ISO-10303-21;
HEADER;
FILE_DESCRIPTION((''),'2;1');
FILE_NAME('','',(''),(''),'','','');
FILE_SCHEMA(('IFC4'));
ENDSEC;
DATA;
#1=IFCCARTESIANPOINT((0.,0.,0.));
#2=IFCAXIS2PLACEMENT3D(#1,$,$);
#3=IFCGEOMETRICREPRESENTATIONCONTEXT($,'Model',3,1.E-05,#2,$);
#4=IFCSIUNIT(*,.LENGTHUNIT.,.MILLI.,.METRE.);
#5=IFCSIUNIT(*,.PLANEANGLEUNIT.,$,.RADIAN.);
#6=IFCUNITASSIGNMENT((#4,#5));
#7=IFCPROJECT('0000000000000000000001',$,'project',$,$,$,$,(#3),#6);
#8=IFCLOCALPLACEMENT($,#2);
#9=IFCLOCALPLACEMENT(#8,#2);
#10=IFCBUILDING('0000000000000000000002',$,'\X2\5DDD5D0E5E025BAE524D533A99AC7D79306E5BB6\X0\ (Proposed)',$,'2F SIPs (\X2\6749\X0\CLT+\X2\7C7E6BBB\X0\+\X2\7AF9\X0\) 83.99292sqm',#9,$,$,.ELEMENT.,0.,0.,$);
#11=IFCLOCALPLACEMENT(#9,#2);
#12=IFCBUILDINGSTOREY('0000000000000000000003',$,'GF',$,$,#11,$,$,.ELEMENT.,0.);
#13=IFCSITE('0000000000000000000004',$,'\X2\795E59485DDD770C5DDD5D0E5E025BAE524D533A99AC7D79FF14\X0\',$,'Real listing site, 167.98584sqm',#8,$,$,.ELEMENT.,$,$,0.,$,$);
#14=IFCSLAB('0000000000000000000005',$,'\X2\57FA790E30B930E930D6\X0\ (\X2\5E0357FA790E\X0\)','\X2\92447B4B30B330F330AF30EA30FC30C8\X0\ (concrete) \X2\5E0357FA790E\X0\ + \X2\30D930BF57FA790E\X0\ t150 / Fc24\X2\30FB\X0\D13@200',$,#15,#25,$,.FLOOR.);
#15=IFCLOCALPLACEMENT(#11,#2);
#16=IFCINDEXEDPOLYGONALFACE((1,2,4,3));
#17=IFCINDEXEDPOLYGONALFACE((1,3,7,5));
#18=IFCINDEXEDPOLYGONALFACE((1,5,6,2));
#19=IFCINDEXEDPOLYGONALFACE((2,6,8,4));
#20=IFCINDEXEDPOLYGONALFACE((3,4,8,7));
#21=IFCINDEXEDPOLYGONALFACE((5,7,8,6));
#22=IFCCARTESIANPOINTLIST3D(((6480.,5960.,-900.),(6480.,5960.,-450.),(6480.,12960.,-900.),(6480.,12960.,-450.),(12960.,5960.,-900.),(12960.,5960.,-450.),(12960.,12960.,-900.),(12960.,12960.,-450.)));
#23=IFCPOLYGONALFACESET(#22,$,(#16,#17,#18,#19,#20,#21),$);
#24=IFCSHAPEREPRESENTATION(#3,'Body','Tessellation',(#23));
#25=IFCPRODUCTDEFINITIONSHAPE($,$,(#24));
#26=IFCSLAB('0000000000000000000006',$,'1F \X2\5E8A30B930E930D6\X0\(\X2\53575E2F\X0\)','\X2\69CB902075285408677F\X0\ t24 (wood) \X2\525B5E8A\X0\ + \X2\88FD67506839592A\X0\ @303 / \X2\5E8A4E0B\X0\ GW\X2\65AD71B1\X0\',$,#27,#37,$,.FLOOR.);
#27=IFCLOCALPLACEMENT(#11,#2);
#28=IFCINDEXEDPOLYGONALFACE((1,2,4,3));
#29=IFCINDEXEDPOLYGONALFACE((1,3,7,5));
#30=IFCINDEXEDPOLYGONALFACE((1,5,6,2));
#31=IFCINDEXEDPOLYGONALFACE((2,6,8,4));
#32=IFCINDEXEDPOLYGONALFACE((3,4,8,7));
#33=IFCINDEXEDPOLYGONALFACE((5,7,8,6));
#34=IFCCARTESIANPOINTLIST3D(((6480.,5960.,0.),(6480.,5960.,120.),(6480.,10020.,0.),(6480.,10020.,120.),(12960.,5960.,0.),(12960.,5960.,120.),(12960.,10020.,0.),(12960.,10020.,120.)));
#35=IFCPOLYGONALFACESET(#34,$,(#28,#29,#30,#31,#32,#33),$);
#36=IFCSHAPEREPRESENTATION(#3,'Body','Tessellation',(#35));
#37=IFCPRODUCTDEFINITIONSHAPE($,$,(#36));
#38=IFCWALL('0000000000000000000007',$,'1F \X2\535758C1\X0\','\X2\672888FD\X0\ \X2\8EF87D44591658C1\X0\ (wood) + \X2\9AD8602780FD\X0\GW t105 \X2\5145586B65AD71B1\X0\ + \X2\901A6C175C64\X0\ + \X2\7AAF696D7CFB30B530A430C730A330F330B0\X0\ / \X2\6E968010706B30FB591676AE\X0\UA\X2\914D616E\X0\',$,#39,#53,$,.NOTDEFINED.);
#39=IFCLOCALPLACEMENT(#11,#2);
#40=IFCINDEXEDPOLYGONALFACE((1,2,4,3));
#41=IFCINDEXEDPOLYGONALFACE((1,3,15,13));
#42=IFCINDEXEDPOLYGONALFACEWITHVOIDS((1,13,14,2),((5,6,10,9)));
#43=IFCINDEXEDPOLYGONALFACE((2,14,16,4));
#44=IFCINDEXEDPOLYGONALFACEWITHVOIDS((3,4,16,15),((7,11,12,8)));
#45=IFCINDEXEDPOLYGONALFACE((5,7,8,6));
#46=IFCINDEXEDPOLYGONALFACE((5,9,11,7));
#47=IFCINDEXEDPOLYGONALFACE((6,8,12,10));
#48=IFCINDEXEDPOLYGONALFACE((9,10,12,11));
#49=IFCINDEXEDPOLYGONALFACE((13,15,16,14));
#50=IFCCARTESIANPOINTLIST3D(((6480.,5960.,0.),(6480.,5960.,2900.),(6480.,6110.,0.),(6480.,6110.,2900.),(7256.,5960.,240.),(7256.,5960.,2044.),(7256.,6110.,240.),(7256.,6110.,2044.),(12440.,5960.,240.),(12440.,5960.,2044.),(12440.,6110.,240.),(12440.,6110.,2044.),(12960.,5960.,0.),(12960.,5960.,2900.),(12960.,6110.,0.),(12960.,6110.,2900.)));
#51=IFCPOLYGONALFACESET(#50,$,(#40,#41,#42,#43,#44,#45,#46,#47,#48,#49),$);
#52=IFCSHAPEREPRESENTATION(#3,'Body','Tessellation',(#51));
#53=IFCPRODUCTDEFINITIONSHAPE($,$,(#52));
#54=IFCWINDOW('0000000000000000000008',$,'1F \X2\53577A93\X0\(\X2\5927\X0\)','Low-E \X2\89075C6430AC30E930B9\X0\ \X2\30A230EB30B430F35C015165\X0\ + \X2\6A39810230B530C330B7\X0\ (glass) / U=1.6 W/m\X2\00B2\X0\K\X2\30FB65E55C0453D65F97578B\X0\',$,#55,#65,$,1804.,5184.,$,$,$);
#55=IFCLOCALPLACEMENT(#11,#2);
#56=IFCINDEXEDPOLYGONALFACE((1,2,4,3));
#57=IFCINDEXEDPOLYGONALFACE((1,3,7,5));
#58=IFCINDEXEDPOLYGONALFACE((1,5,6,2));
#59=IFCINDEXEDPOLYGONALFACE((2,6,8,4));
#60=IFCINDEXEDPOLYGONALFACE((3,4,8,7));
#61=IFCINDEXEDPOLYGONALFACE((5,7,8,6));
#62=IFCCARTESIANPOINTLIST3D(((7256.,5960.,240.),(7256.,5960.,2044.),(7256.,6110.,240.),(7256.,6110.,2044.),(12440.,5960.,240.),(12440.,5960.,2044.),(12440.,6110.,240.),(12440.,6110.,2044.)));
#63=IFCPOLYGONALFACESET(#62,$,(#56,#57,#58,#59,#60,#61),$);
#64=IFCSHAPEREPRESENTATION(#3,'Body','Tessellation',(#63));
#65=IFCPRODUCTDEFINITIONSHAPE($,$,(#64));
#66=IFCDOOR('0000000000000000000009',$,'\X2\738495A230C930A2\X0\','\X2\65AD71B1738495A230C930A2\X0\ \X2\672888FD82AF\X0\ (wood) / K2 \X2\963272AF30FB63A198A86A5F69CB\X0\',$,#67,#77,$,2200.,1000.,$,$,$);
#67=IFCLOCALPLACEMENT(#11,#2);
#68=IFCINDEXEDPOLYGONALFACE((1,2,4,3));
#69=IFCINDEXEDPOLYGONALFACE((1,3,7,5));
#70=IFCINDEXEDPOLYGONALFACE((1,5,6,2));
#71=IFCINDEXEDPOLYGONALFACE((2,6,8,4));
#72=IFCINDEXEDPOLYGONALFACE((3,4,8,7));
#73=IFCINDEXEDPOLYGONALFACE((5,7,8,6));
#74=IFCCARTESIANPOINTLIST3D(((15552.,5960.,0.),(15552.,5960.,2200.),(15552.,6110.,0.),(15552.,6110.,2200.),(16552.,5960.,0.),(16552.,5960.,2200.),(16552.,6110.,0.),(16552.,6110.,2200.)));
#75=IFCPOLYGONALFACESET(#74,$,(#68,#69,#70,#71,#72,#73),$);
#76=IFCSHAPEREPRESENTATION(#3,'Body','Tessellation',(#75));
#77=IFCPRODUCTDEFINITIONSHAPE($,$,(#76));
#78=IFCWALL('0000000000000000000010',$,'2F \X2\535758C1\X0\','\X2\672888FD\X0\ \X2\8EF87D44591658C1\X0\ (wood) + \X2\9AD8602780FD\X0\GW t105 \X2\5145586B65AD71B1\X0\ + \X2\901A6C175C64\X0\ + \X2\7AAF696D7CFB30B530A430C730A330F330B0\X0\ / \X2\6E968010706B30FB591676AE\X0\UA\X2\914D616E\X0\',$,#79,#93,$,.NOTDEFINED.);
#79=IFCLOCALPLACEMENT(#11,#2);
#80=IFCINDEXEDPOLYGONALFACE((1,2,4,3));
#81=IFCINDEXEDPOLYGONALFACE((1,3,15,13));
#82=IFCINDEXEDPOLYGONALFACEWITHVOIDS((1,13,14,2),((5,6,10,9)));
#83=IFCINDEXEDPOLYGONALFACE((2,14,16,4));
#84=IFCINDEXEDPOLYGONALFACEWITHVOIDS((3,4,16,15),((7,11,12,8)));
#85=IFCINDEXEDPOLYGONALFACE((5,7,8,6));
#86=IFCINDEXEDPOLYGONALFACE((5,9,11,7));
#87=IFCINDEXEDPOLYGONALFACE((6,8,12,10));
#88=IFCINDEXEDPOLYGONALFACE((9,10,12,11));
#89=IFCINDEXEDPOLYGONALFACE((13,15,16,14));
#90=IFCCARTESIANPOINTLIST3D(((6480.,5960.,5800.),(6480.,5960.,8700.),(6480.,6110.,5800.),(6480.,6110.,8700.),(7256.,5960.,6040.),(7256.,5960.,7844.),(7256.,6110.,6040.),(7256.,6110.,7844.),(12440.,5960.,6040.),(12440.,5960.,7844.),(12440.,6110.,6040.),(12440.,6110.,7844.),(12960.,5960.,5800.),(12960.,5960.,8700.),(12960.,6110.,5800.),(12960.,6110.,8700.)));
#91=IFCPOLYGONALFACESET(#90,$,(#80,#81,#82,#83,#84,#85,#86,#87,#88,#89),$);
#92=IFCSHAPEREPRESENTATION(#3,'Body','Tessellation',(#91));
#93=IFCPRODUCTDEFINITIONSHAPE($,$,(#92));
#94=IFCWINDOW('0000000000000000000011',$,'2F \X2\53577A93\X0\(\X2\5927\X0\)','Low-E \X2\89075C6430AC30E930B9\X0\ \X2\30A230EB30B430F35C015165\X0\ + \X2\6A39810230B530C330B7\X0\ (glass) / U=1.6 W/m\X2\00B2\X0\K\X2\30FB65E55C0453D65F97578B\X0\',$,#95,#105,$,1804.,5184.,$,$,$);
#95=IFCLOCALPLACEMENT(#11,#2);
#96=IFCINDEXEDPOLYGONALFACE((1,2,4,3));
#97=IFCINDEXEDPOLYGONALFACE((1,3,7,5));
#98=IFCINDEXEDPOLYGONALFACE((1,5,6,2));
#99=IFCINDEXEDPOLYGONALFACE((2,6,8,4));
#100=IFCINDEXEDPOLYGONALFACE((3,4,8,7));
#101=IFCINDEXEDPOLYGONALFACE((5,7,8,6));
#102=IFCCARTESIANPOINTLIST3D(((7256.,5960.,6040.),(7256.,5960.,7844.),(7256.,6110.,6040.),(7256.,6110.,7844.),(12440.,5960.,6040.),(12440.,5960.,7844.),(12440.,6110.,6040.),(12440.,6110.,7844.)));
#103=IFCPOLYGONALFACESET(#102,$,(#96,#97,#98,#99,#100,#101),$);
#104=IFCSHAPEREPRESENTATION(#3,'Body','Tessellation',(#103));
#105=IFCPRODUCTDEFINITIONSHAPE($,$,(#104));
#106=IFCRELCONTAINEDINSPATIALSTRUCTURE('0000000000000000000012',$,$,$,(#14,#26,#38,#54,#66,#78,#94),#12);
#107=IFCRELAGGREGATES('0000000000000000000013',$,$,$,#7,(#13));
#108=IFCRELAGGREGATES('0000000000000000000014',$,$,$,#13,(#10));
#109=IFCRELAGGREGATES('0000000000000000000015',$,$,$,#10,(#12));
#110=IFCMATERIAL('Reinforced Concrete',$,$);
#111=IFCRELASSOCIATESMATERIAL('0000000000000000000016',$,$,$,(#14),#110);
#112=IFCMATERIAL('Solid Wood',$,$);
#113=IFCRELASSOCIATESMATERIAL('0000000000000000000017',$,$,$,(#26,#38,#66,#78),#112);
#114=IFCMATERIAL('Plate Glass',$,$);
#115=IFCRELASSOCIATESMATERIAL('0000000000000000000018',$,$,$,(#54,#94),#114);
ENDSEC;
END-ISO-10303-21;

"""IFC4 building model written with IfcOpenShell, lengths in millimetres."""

from ifc_helpers import new_model, si_unit, frame, frame_2d, origin, place, context, project, spatial, rectangle, extrude, material, element, fill, save


model = new_model("IFC4")

# Units and contexts
model_context = context("Model", 3, precision=1e-05, world=origin())
ifc_project = project(units=[si_unit("LENGTHUNIT", "METRE", prefix="MILLI"), si_unit("PLANEANGLEUNIT", "RADIAN")], contexts=[model_context])

# Site, building, storey
site_placement = place(None, origin())
site = spatial("IfcSite", under=ifc_project, at=site_placement, Name="神奈川県川崎市宮前区馬絹４", ObjectType="Real listing site, 167.98584sqm", CompositionType="ELEMENT", RefElevation=0.0)
building_placement = place(site_placement, origin())
building = spatial("IfcBuilding", under=site, at=building_placement, Name="川崎市宮前区馬絹の家 (Proposed)", ObjectType="2F SIPs (杉CLT+籾殻+竹) 83.99292sqm", CompositionType="ELEMENT", ElevationOfRefHeight=0.0, ElevationOfTerrain=0.0)
storey_placement = place(building_placement, origin())
storey = spatial("IfcBuildingStorey", under=building, at=storey_placement, Name="GF", CompositionType="ELEMENT", Elevation=0.0)

# Slabs
ifc_material_1 = material(Name="Reinforced Concrete")
slab_1_placement = place(storey_placement, frame((3240.0, 2980.0, -450.0)))
element("IfcSlab", 1, at=slab_1_placement, inside=storey, material=ifc_material_1, Name="基礎スラブ (布基礎)", Description="鉄筋コンクリート (concrete) 布基礎 + ベタ基礎 t150 / Fc24・D13@200", PredefinedType="FLOOR", context=model_context, shape_type="SweptSolid", body=[
    extrude(rectangle(XDim=6480.0, YDim=7000.0, at=frame_2d((3240.0, 3500.0))), frame((3240.0, 2980.0, -450.0)), (0.0, 0.0, 1.0), 450.0),
])
ifc_material_2 = material(Name="Solid Wood")
slab_2_placement = place(storey_placement, frame((3240.0, 2980.0, 0.0)))
element("IfcSlab", 2, at=slab_2_placement, inside=storey, material=ifc_material_2, Name="1F 床スラブ(南帯)", Description="構造用合板 t24 (wood) 剛床 + 製材根太 @303 / 床下 GW断熱", PredefinedType="FLOOR", context=model_context, shape_type="SweptSolid", body=[
    extrude(rectangle(XDim=6480.0, YDim=4060.0, at=frame_2d((3240.0, 2030.0))), frame((3240.0, 2980.0, 0.0)), (0.0, 0.0, 1.0), 120.0),
])

# Wall, openings, window, door
wall_1_placement = place(storey_placement, frame((3240.0, 2980.0, 0.0)))
wall_1 = element("IfcWall", 3, at=wall_1_placement, inside=storey, material=ifc_material_2, Name="1F 南壁", Description="木製 軸組外壁 (wood) + 高性能GW t105 充填断熱 + 通気層 + 窯業系サイディング / 準耐火・外皮UA配慮", PredefinedType="NOTDEFINED", context=model_context, shape_type="SweptSolid", body=[
    extrude(rectangle(XDim=6480.0, YDim=150.0, at=frame_2d((3240.0, 75.0))), frame((3240.0, 2980.0, 0.0)), (0.0, 0.0, 1.0), 2900.0),
])
opening_1_placement = place(storey_placement, frame((3628.0, 2980.0, 120.0)))
opening_1 = element("IfcOpeningElement", 4, at=opening_1_placement, cuts=wall_1, PredefinedType="NOTDEFINED", context=model_context, shape_type="SweptSolid", body=[
    extrude(rectangle(XDim=5184.0, YDim=150.0, at=frame_2d((2592.0, 75.0))), frame((3628.0, 2980.0, 120.0)), (0.0, 0.0, 1.0), 1804.0),
])
opening_2_placement = place(storey_placement, frame((7776.0, 2980.0, 0.0)))
opening_2 = element("IfcOpeningElement", 5, at=opening_2_placement, cuts=wall_1, PredefinedType="NOTDEFINED", context=model_context, shape_type="SweptSolid", body=[
    extrude(rectangle(XDim=1000.0, YDim=150.0, at=frame_2d((500.0, 75.0))), frame((7776.0, 2980.0, 0.0)), (0.0, 0.0, 1.0), 2200.0),
])
ifc_material_3 = material(Name="Plate Glass")
window_1_placement = place(storey_placement, frame((3628.0, 2980.0, 120.0)))
window_1 = element("IfcWindow", 6, at=window_1_placement, inside=storey, material=ifc_material_3, Name="1F 南窓(大)", Description="Low-E 複層ガラス アルゴン封入 + 樹脂サッシ (glass) / U=1.6 W/m²K・日射取得型", OverallHeight=1804.0, OverallWidth=5184.0, context=model_context, shape_type="SweptSolid", body=[
    extrude(rectangle(XDim=5184.0, YDim=150.0, at=frame_2d((2592.0, 75.0))), frame((3628.0, 2980.0, 120.0)), (0.0, 0.0, 1.0), 1804.0),
])
fill(opening_1, window_1)
door_placement = place(storey_placement, frame((7776.0, 2980.0, 0.0)))
door = element("IfcDoor", 7, at=door_placement, inside=storey, material=ifc_material_2, Name="玄関ドア", Description="断熱玄関ドア 木製芯 (wood) / K2 防犯・採風機構", OverallHeight=2200.0, OverallWidth=1000.0, context=model_context, shape_type="SweptSolid", body=[
    extrude(rectangle(XDim=1000.0, YDim=150.0, at=frame_2d((500.0, 75.0))), frame((7776.0, 2980.0, 0.0)), (0.0, 0.0, 1.0), 2200.0),
])
fill(opening_2, door)

# Wall, opening, window
wall_2_placement = place(storey_placement, frame((3240.0, 2980.0, 2900.0)))
wall_2 = element("IfcWall", 8, at=wall_2_placement, inside=storey, material=ifc_material_2, Name="2F 南壁", Description="木製 軸組外壁 (wood) + 高性能GW t105 充填断熱 + 通気層 + 窯業系サイディング / 準耐火・外皮UA配慮", PredefinedType="NOTDEFINED", context=model_context, shape_type="SweptSolid", body=[
    extrude(rectangle(XDim=6480.0, YDim=150.0, at=frame_2d((3240.0, 75.0))), frame((3240.0, 2980.0, 2900.0)), (0.0, 0.0, 1.0), 2900.0),
])
opening_3_placement = place(storey_placement, frame((3628.0, 2980.0, 3020.0)))
opening_3 = element("IfcOpeningElement", 9, at=opening_3_placement, cuts=wall_2, PredefinedType="NOTDEFINED", context=model_context, shape_type="SweptSolid", body=[
    extrude(rectangle(XDim=5184.0, YDim=150.0, at=frame_2d((2592.0, 75.0))), frame((3628.0, 2980.0, 3020.0)), (0.0, 0.0, 1.0), 1804.0),
])
window_2_placement = place(storey_placement, frame((3628.0, 2980.0, 3020.0)))
window_2 = element("IfcWindow", 10, at=window_2_placement, inside=storey, material=ifc_material_3, Name="2F 南窓(大)", Description="Low-E 複層ガラス アルゴン封入 + 樹脂サッシ (glass) / U=1.6 W/m²K・日射取得型", OverallHeight=1804.0, OverallWidth=5184.0, context=model_context, shape_type="SweptSolid", body=[
    extrude(rectangle(XDim=5184.0, YDim=150.0, at=frame_2d((2592.0, 75.0))), frame((3628.0, 2980.0, 3020.0)), (0.0, 0.0, 1.0), 1804.0),
])
fill(opening_3, window_2)

save(model, "model.ifc")
